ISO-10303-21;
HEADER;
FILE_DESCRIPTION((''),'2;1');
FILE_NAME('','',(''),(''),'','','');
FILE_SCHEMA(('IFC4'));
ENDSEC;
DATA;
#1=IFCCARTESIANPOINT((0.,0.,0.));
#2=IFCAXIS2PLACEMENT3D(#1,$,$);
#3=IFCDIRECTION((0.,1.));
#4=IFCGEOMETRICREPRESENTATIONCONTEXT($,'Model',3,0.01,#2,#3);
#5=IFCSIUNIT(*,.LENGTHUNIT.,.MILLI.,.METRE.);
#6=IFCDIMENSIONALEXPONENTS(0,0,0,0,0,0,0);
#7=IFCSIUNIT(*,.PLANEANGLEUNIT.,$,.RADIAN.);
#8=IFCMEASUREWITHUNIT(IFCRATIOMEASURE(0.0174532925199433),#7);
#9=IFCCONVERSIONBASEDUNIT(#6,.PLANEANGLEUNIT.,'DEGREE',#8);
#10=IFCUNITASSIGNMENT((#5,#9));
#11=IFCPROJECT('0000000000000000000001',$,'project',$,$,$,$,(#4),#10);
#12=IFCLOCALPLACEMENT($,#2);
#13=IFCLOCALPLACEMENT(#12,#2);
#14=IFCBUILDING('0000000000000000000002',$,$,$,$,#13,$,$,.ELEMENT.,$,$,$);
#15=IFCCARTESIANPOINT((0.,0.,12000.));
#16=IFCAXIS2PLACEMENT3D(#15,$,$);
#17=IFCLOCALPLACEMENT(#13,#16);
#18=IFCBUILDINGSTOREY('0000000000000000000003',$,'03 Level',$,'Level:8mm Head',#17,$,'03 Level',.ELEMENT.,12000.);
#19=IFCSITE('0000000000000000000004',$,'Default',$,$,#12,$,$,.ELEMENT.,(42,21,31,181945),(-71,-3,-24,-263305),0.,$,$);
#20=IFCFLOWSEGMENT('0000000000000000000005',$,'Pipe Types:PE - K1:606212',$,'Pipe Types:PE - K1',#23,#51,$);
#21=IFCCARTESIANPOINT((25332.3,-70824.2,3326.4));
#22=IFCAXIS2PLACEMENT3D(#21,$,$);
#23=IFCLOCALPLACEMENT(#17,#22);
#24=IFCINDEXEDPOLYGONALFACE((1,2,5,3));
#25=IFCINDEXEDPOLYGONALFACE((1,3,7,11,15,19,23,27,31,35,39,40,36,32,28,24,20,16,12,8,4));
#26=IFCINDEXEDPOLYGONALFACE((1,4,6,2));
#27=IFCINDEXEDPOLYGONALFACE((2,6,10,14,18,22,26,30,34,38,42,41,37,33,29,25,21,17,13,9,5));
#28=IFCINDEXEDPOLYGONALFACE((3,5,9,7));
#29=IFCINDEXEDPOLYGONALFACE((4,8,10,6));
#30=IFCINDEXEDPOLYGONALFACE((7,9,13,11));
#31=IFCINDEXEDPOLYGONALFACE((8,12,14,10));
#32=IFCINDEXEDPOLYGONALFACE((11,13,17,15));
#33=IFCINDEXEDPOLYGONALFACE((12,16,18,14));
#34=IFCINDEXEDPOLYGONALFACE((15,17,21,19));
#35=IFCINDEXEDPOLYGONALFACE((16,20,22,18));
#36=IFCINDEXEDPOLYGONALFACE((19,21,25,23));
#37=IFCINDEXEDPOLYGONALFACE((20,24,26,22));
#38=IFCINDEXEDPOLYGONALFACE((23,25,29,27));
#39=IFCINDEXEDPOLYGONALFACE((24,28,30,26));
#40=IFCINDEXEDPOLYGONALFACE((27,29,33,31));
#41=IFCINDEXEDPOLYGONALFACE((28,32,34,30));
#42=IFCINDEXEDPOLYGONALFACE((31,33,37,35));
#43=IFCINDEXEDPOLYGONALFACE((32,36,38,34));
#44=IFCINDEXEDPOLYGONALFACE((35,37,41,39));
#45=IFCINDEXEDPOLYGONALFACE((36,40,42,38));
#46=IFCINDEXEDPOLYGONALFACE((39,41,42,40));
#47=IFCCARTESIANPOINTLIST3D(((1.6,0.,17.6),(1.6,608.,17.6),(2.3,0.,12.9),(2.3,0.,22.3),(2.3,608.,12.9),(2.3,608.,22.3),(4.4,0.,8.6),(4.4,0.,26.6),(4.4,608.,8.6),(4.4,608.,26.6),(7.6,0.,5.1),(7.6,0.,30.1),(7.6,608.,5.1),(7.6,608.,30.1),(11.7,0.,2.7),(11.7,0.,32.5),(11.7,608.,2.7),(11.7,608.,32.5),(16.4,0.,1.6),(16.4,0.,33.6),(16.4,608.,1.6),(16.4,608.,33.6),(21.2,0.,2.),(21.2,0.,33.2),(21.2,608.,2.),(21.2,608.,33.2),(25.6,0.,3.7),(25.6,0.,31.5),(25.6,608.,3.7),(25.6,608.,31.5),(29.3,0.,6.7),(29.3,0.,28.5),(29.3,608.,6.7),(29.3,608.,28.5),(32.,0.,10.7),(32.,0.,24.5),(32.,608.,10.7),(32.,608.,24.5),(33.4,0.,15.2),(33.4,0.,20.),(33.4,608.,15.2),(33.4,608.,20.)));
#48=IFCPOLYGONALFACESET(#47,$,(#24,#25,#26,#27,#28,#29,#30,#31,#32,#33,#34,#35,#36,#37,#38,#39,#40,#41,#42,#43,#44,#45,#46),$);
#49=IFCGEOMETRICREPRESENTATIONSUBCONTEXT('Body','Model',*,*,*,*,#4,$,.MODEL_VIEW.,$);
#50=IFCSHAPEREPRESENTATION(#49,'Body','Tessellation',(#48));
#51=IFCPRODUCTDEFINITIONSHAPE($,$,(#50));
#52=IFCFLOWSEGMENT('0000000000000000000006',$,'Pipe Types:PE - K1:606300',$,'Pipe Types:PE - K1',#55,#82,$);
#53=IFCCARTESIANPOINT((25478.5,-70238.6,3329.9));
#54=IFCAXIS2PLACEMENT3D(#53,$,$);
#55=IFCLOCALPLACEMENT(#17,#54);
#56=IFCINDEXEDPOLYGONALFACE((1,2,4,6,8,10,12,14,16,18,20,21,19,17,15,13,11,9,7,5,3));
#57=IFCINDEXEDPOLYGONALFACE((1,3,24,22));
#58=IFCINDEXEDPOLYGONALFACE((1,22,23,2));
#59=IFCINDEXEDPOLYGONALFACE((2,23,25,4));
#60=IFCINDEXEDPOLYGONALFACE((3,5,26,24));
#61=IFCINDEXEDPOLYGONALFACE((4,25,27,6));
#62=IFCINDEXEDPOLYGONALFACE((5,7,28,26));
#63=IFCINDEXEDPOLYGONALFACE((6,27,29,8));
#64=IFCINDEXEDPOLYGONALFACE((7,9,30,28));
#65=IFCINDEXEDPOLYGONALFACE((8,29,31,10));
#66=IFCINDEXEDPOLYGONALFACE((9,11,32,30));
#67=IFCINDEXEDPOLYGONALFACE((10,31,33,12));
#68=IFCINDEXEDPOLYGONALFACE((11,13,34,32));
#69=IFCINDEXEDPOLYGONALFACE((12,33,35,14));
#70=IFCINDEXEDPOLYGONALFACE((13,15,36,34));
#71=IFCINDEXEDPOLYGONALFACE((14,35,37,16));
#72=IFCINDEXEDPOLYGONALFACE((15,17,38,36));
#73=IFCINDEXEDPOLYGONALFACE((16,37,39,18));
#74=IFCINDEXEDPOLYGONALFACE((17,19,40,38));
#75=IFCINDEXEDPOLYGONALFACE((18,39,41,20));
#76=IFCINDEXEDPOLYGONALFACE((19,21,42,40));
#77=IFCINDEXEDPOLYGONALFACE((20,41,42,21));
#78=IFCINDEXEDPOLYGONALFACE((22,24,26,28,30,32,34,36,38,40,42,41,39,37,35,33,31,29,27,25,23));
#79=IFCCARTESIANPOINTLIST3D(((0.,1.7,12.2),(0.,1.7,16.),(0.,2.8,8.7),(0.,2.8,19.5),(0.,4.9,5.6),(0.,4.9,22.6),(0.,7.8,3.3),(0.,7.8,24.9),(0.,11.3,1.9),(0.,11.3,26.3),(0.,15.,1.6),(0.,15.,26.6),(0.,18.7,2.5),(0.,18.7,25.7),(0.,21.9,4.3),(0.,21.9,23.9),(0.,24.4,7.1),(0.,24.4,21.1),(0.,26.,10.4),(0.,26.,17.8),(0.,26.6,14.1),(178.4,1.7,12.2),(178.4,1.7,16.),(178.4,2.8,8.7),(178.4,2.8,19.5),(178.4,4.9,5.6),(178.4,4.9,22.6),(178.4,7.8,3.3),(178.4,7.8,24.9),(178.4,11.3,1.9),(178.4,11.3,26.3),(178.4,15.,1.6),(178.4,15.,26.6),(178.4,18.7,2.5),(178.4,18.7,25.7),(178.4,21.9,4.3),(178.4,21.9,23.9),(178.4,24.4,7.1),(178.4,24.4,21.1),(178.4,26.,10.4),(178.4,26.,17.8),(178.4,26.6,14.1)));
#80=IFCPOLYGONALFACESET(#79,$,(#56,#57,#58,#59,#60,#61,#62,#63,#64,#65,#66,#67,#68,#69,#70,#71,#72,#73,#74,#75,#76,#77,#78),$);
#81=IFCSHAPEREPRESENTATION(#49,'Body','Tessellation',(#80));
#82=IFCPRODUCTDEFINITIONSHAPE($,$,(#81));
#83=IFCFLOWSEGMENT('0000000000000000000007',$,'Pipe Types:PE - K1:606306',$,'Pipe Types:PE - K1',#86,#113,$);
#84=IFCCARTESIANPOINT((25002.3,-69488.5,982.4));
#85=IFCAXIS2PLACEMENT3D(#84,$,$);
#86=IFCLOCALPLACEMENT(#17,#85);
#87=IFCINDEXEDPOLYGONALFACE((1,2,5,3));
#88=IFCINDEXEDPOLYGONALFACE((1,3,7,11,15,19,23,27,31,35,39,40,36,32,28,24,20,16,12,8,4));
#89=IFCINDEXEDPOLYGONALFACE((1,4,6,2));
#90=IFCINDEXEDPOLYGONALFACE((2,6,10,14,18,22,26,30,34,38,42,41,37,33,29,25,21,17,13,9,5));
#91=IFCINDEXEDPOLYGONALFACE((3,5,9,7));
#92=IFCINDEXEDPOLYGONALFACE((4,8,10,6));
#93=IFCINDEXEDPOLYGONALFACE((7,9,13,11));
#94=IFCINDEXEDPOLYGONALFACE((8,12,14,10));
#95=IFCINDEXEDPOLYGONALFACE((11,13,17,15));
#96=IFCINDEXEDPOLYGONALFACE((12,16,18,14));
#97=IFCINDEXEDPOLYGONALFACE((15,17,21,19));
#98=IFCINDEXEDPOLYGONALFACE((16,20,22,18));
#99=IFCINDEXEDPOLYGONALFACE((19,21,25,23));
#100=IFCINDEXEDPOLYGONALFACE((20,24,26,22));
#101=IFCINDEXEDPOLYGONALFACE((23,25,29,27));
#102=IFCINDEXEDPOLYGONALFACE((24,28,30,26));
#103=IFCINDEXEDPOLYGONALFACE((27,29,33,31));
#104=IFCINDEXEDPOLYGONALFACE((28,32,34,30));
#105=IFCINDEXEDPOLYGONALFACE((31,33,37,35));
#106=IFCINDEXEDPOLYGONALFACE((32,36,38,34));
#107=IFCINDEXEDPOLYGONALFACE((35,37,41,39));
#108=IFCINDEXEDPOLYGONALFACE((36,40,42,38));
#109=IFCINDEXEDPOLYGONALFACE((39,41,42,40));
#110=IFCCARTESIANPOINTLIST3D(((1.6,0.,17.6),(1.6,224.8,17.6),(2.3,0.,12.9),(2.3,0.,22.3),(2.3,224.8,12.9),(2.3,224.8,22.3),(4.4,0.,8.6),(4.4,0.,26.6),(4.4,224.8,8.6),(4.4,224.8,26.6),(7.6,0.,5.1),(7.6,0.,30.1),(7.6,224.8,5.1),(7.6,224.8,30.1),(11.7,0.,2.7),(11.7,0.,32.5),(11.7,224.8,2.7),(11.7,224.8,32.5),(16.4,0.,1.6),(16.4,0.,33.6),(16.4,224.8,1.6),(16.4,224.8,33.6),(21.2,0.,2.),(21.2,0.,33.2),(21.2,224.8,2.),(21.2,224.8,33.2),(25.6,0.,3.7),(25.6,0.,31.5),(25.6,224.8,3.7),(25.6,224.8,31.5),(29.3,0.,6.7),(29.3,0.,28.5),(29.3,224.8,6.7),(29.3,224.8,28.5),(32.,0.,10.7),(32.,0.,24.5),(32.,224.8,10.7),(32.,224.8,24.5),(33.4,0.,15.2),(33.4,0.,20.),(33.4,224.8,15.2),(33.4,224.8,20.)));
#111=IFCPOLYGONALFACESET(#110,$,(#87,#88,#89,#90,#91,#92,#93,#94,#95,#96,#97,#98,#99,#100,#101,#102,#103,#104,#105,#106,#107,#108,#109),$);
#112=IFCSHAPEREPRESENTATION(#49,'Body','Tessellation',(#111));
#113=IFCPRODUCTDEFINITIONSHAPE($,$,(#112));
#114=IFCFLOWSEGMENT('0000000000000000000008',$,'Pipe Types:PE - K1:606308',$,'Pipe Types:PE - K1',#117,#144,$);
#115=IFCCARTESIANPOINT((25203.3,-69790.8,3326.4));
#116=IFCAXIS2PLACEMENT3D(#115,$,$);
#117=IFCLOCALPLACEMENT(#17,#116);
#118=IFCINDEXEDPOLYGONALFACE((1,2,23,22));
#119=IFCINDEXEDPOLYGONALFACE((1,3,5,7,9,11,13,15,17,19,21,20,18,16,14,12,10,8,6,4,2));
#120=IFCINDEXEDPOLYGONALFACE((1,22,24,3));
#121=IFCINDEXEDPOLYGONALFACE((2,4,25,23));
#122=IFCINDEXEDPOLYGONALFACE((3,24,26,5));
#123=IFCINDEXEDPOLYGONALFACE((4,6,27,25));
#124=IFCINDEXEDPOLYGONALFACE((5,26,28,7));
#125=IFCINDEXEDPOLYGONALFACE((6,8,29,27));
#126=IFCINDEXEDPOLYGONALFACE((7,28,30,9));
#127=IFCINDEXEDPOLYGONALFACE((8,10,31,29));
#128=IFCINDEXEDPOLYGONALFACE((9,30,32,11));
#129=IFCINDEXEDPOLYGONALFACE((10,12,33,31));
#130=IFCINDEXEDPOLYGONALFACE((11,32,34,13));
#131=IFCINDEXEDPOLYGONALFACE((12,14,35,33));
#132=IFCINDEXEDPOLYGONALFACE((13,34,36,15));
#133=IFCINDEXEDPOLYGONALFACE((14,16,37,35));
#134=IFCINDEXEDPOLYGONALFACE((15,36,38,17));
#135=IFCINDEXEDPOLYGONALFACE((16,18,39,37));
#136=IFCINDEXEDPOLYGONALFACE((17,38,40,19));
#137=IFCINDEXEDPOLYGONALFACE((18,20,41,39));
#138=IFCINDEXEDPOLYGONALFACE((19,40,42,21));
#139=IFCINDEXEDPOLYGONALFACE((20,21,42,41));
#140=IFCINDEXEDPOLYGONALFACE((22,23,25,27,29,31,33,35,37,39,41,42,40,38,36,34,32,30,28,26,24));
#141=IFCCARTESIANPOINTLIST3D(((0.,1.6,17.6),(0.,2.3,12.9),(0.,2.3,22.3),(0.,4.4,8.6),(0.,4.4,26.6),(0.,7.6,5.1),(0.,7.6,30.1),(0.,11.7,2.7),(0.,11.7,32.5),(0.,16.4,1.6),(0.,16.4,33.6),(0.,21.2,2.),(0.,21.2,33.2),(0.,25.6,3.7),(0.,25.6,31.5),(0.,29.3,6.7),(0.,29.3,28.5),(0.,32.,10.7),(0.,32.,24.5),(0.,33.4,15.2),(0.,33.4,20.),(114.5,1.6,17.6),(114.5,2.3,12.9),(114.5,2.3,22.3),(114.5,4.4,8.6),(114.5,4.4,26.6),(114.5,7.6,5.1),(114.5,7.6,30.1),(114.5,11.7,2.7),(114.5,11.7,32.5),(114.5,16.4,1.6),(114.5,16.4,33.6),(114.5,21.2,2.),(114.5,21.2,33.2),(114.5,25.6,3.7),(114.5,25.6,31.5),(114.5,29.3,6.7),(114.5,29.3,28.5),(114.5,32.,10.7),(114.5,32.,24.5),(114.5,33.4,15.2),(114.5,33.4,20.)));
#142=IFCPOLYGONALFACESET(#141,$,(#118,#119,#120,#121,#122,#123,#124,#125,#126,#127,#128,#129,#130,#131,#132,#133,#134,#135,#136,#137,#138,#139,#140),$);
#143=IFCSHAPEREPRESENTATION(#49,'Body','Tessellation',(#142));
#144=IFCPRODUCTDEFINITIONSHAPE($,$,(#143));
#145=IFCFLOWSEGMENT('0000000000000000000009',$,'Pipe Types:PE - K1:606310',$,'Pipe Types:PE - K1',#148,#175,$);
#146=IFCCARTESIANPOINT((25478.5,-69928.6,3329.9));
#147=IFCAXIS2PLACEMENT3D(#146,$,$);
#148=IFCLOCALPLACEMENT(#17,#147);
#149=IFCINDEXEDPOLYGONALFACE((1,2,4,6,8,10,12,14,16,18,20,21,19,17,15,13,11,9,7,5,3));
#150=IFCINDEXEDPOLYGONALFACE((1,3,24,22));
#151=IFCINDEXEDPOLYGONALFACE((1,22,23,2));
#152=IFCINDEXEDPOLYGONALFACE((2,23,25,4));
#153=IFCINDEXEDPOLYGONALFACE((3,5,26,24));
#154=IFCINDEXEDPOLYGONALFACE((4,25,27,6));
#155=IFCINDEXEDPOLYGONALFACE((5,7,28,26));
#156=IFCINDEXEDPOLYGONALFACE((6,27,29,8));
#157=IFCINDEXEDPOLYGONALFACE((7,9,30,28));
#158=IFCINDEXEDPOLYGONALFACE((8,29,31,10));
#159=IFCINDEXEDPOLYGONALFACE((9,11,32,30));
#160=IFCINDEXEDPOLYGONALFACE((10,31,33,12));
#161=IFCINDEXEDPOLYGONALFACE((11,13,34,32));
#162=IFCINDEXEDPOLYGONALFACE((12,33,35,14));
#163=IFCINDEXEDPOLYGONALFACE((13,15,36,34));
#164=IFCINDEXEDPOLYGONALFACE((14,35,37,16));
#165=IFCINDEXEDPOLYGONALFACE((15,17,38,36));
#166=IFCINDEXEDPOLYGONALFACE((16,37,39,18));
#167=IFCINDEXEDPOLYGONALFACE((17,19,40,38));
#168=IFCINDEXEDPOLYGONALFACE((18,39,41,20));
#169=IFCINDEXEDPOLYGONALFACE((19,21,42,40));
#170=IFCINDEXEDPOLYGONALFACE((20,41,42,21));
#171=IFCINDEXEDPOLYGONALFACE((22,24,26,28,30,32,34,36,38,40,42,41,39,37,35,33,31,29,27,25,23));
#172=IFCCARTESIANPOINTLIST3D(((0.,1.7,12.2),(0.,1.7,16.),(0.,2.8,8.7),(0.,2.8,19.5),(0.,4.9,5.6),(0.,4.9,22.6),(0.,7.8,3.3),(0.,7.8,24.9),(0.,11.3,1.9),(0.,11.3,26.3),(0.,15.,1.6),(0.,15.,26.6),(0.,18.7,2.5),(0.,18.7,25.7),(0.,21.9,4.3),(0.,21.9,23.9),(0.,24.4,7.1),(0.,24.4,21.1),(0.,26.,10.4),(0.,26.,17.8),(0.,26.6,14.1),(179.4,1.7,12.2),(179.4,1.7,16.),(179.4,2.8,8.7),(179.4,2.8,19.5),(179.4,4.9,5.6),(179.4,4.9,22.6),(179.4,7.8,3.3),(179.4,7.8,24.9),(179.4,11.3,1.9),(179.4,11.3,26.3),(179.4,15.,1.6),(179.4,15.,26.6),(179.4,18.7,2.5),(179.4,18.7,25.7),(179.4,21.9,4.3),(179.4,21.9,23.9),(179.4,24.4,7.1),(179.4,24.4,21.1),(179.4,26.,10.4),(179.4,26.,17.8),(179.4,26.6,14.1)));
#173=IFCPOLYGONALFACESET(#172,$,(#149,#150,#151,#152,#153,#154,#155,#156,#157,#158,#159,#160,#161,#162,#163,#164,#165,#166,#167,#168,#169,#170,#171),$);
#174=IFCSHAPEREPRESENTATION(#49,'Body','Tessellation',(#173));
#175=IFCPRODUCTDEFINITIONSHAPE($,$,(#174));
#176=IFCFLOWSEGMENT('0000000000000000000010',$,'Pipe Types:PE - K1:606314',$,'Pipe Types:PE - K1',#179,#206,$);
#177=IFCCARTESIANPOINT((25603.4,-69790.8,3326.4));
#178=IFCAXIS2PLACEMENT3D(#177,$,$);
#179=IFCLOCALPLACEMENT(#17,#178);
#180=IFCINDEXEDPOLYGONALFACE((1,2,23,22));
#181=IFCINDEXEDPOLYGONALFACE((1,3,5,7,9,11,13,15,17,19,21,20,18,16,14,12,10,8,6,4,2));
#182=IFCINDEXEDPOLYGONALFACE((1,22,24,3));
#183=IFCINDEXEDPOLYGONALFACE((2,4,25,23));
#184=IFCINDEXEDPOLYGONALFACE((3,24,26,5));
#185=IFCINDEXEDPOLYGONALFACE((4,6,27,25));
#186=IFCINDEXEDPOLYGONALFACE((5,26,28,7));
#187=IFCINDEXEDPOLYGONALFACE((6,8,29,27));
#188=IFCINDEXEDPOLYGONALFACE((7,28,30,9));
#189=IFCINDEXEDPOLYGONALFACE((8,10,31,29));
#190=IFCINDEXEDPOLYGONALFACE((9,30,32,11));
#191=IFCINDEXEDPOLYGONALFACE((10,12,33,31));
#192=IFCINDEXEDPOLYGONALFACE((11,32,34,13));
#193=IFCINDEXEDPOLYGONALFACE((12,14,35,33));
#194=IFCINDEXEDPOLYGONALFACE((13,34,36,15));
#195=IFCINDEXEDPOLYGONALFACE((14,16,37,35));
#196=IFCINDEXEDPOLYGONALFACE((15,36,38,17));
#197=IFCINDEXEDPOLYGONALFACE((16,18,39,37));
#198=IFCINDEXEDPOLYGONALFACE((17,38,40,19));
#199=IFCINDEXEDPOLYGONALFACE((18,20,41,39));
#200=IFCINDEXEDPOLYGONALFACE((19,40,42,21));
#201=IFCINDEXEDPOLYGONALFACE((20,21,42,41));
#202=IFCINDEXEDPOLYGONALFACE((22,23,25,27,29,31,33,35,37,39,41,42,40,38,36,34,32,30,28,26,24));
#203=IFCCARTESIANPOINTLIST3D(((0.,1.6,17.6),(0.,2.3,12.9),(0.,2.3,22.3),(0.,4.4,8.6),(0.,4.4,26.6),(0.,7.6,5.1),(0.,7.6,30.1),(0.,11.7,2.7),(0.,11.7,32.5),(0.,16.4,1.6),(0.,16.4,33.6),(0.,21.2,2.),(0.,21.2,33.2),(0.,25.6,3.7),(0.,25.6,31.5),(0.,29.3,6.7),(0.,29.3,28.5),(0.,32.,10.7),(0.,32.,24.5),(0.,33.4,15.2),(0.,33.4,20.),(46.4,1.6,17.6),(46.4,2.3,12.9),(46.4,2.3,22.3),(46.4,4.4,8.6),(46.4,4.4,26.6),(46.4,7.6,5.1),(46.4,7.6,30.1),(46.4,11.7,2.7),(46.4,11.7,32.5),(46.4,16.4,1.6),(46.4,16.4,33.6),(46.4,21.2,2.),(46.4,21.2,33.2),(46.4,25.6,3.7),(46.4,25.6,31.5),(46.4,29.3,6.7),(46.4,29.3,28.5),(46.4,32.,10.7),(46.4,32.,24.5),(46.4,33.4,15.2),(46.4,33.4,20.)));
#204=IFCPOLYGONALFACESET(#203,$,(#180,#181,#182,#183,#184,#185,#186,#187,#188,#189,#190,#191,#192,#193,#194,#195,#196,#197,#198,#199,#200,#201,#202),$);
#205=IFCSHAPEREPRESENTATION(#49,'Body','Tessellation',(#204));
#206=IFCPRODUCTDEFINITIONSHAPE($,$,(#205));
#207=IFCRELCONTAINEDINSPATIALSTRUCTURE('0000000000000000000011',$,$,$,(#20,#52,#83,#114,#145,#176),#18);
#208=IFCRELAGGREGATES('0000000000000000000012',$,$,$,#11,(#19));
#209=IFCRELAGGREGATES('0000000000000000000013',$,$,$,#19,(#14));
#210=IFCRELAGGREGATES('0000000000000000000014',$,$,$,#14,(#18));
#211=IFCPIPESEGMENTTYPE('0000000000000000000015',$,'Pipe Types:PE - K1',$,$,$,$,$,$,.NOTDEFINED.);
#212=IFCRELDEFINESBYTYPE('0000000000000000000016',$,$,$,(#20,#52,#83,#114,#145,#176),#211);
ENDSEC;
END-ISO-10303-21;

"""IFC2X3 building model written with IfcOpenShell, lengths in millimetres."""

from ifc_helpers import new_model, entity, si_unit, converted_unit, direction, frame, frame_2d, origin, origin_2d_with_axis, place, context, subcontext, project, spatial, circle, extrude, type_object, element, save


model = new_model("IFC2X3")

# Units and contexts
model_context = context("Model", 3, precision=0.01, world=origin(), true_north=direction((0.0, 1.0)))
body_context = subcontext(model_context, "Body", "Model", "MODEL_VIEW")
ifc_project = project(units=[si_unit("LENGTHUNIT", "METRE", prefix="MILLI"), converted_unit("PLANEANGLEUNIT", "DEGREE", entity("IfcRatioMeasure", 0.0174532925199433), si_unit("PLANEANGLEUNIT", "RADIAN"), dimensions=[0, 0, 0, 0, 0, 0, 0])], contexts=[model_context])

# Site, building, storey
site_placement = place(None, origin())
site = spatial("IfcSite", under=ifc_project, at=site_placement, Name="Default", CompositionType="ELEMENT", RefLatitude=(42, 21, 31, 181945), RefLongitude=(-71, -3, -24, -263305), RefElevation=0.0)
building_placement = place(site_placement, origin())
building = spatial("IfcBuilding", under=site, at=building_placement, CompositionType="ELEMENT")
storey_placement = place(building_placement, frame((0.0, 0.0, 12000.0)))
storey = spatial("IfcBuildingStorey", under=building, at=storey_placement, Name="03 Level", ObjectType="Level:8mm Head", LongName="03 Level", CompositionType="ELEMENT", Elevation=12000.0)

# Flow segments
pipe_segment_type = type_object("IfcPipeSegmentType", Name="Pipe Types:PE - K1", PredefinedType="NOTDEFINED")
flow_segment_1_placement = place(storey_placement, frame((25332.3, -70824.2, 3326.4)))
element("IfcFlowSegment", 1, at=flow_segment_1_placement, inside=storey, type_object=pipe_segment_type, Name="Pipe Types:PE - K1:606212", ObjectType="Pipe Types:PE - K1", context=body_context, shape_type="SweptSolid", body=[
    extrude(circle(Radius=16.0, at=frame_2d((0.0, 0.0), x_axis=(1.0, 0.0))), frame((17.6, 0.0, 17.6), z_axis=(0.0, 1.0, 0.0), x_axis=(-1.0, 0.0, 0.0)), (0.0, 0.0, 1.0), 608.0),
])
flow_segment_2_placement = place(storey_placement, frame((25478.5, -70238.6, 3329.9)))
element("IfcFlowSegment", 2, at=flow_segment_2_placement, inside=storey, type_object=pipe_segment_type, Name="Pipe Types:PE - K1:606300", ObjectType="Pipe Types:PE - K1", context=body_context, shape_type="SweptSolid", body=[
    extrude(circle(Radius=12.5, at=frame_2d((0.0, 0.0), x_axis=(1.0, 0.0))), frame((0.0, 14.1, 14.1), z_axis=(1.0, 0.0, 0.0), x_axis=(0.0, 1.0, 0.0)), (0.0, 0.0, 1.0), 178.4),
])
flow_segment_3_placement = place(storey_placement, frame((25002.3, -69488.5, 982.4)))
element("IfcFlowSegment", 3, at=flow_segment_3_placement, inside=storey, type_object=pipe_segment_type, Name="Pipe Types:PE - K1:606306", ObjectType="Pipe Types:PE - K1", context=body_context, shape_type="SweptSolid", body=[
    extrude(circle(Radius=16.0, at=origin_2d_with_axis()), frame((17.6, 0.0, 17.6), z_axis=(0.0, 1.0, 0.0), x_axis=(-1.0, 0.0, 0.0)), (0.0, 0.0, 1.0), 224.8),
])
flow_segment_4_placement = place(storey_placement, frame((25203.3, -69790.8, 3326.4)))
element("IfcFlowSegment", 4, at=flow_segment_4_placement, inside=storey, type_object=pipe_segment_type, Name="Pipe Types:PE - K1:606308", ObjectType="Pipe Types:PE - K1", context=body_context, shape_type="SweptSolid", body=[
    extrude(circle(Radius=16.0, at=origin_2d_with_axis()), frame((0.0, 17.6, 17.6), z_axis=(1.0, 0.0, 0.0), x_axis=(0.0, -1.0, 0.0)), (0.0, 0.0, 1.0), 114.5),
])
flow_segment_5_placement = place(storey_placement, frame((25478.5, -69928.6, 3329.9)))
element("IfcFlowSegment", 5, at=flow_segment_5_placement, inside=storey, type_object=pipe_segment_type, Name="Pipe Types:PE - K1:606310", ObjectType="Pipe Types:PE - K1", context=body_context, shape_type="SweptSolid", body=[
    extrude(circle(Radius=12.5, at=frame_2d((0.0, 0.0), x_axis=(1.0, 0.0))), frame((0.0, 14.1, 14.1), z_axis=(1.0, 0.0, 0.0), x_axis=(0.0, 1.0, 0.0)), (0.0, 0.0, 1.0), 179.4),
])
flow_segment_6_placement = place(storey_placement, frame((25603.4, -69790.8, 3326.4)))
element("IfcFlowSegment", 6, at=flow_segment_6_placement, inside=storey, type_object=pipe_segment_type, Name="Pipe Types:PE - K1:606314", ObjectType="Pipe Types:PE - K1", context=body_context, shape_type="SweptSolid", body=[
    extrude(circle(Radius=16.0, at=origin_2d_with_axis()), frame((0.0, 17.6, 17.6), z_axis=(1.0, 0.0, 0.0), x_axis=(0.0, -1.0, 0.0)), (0.0, 0.0, 1.0), 46.4),
])

save(model, "model.ifc")
